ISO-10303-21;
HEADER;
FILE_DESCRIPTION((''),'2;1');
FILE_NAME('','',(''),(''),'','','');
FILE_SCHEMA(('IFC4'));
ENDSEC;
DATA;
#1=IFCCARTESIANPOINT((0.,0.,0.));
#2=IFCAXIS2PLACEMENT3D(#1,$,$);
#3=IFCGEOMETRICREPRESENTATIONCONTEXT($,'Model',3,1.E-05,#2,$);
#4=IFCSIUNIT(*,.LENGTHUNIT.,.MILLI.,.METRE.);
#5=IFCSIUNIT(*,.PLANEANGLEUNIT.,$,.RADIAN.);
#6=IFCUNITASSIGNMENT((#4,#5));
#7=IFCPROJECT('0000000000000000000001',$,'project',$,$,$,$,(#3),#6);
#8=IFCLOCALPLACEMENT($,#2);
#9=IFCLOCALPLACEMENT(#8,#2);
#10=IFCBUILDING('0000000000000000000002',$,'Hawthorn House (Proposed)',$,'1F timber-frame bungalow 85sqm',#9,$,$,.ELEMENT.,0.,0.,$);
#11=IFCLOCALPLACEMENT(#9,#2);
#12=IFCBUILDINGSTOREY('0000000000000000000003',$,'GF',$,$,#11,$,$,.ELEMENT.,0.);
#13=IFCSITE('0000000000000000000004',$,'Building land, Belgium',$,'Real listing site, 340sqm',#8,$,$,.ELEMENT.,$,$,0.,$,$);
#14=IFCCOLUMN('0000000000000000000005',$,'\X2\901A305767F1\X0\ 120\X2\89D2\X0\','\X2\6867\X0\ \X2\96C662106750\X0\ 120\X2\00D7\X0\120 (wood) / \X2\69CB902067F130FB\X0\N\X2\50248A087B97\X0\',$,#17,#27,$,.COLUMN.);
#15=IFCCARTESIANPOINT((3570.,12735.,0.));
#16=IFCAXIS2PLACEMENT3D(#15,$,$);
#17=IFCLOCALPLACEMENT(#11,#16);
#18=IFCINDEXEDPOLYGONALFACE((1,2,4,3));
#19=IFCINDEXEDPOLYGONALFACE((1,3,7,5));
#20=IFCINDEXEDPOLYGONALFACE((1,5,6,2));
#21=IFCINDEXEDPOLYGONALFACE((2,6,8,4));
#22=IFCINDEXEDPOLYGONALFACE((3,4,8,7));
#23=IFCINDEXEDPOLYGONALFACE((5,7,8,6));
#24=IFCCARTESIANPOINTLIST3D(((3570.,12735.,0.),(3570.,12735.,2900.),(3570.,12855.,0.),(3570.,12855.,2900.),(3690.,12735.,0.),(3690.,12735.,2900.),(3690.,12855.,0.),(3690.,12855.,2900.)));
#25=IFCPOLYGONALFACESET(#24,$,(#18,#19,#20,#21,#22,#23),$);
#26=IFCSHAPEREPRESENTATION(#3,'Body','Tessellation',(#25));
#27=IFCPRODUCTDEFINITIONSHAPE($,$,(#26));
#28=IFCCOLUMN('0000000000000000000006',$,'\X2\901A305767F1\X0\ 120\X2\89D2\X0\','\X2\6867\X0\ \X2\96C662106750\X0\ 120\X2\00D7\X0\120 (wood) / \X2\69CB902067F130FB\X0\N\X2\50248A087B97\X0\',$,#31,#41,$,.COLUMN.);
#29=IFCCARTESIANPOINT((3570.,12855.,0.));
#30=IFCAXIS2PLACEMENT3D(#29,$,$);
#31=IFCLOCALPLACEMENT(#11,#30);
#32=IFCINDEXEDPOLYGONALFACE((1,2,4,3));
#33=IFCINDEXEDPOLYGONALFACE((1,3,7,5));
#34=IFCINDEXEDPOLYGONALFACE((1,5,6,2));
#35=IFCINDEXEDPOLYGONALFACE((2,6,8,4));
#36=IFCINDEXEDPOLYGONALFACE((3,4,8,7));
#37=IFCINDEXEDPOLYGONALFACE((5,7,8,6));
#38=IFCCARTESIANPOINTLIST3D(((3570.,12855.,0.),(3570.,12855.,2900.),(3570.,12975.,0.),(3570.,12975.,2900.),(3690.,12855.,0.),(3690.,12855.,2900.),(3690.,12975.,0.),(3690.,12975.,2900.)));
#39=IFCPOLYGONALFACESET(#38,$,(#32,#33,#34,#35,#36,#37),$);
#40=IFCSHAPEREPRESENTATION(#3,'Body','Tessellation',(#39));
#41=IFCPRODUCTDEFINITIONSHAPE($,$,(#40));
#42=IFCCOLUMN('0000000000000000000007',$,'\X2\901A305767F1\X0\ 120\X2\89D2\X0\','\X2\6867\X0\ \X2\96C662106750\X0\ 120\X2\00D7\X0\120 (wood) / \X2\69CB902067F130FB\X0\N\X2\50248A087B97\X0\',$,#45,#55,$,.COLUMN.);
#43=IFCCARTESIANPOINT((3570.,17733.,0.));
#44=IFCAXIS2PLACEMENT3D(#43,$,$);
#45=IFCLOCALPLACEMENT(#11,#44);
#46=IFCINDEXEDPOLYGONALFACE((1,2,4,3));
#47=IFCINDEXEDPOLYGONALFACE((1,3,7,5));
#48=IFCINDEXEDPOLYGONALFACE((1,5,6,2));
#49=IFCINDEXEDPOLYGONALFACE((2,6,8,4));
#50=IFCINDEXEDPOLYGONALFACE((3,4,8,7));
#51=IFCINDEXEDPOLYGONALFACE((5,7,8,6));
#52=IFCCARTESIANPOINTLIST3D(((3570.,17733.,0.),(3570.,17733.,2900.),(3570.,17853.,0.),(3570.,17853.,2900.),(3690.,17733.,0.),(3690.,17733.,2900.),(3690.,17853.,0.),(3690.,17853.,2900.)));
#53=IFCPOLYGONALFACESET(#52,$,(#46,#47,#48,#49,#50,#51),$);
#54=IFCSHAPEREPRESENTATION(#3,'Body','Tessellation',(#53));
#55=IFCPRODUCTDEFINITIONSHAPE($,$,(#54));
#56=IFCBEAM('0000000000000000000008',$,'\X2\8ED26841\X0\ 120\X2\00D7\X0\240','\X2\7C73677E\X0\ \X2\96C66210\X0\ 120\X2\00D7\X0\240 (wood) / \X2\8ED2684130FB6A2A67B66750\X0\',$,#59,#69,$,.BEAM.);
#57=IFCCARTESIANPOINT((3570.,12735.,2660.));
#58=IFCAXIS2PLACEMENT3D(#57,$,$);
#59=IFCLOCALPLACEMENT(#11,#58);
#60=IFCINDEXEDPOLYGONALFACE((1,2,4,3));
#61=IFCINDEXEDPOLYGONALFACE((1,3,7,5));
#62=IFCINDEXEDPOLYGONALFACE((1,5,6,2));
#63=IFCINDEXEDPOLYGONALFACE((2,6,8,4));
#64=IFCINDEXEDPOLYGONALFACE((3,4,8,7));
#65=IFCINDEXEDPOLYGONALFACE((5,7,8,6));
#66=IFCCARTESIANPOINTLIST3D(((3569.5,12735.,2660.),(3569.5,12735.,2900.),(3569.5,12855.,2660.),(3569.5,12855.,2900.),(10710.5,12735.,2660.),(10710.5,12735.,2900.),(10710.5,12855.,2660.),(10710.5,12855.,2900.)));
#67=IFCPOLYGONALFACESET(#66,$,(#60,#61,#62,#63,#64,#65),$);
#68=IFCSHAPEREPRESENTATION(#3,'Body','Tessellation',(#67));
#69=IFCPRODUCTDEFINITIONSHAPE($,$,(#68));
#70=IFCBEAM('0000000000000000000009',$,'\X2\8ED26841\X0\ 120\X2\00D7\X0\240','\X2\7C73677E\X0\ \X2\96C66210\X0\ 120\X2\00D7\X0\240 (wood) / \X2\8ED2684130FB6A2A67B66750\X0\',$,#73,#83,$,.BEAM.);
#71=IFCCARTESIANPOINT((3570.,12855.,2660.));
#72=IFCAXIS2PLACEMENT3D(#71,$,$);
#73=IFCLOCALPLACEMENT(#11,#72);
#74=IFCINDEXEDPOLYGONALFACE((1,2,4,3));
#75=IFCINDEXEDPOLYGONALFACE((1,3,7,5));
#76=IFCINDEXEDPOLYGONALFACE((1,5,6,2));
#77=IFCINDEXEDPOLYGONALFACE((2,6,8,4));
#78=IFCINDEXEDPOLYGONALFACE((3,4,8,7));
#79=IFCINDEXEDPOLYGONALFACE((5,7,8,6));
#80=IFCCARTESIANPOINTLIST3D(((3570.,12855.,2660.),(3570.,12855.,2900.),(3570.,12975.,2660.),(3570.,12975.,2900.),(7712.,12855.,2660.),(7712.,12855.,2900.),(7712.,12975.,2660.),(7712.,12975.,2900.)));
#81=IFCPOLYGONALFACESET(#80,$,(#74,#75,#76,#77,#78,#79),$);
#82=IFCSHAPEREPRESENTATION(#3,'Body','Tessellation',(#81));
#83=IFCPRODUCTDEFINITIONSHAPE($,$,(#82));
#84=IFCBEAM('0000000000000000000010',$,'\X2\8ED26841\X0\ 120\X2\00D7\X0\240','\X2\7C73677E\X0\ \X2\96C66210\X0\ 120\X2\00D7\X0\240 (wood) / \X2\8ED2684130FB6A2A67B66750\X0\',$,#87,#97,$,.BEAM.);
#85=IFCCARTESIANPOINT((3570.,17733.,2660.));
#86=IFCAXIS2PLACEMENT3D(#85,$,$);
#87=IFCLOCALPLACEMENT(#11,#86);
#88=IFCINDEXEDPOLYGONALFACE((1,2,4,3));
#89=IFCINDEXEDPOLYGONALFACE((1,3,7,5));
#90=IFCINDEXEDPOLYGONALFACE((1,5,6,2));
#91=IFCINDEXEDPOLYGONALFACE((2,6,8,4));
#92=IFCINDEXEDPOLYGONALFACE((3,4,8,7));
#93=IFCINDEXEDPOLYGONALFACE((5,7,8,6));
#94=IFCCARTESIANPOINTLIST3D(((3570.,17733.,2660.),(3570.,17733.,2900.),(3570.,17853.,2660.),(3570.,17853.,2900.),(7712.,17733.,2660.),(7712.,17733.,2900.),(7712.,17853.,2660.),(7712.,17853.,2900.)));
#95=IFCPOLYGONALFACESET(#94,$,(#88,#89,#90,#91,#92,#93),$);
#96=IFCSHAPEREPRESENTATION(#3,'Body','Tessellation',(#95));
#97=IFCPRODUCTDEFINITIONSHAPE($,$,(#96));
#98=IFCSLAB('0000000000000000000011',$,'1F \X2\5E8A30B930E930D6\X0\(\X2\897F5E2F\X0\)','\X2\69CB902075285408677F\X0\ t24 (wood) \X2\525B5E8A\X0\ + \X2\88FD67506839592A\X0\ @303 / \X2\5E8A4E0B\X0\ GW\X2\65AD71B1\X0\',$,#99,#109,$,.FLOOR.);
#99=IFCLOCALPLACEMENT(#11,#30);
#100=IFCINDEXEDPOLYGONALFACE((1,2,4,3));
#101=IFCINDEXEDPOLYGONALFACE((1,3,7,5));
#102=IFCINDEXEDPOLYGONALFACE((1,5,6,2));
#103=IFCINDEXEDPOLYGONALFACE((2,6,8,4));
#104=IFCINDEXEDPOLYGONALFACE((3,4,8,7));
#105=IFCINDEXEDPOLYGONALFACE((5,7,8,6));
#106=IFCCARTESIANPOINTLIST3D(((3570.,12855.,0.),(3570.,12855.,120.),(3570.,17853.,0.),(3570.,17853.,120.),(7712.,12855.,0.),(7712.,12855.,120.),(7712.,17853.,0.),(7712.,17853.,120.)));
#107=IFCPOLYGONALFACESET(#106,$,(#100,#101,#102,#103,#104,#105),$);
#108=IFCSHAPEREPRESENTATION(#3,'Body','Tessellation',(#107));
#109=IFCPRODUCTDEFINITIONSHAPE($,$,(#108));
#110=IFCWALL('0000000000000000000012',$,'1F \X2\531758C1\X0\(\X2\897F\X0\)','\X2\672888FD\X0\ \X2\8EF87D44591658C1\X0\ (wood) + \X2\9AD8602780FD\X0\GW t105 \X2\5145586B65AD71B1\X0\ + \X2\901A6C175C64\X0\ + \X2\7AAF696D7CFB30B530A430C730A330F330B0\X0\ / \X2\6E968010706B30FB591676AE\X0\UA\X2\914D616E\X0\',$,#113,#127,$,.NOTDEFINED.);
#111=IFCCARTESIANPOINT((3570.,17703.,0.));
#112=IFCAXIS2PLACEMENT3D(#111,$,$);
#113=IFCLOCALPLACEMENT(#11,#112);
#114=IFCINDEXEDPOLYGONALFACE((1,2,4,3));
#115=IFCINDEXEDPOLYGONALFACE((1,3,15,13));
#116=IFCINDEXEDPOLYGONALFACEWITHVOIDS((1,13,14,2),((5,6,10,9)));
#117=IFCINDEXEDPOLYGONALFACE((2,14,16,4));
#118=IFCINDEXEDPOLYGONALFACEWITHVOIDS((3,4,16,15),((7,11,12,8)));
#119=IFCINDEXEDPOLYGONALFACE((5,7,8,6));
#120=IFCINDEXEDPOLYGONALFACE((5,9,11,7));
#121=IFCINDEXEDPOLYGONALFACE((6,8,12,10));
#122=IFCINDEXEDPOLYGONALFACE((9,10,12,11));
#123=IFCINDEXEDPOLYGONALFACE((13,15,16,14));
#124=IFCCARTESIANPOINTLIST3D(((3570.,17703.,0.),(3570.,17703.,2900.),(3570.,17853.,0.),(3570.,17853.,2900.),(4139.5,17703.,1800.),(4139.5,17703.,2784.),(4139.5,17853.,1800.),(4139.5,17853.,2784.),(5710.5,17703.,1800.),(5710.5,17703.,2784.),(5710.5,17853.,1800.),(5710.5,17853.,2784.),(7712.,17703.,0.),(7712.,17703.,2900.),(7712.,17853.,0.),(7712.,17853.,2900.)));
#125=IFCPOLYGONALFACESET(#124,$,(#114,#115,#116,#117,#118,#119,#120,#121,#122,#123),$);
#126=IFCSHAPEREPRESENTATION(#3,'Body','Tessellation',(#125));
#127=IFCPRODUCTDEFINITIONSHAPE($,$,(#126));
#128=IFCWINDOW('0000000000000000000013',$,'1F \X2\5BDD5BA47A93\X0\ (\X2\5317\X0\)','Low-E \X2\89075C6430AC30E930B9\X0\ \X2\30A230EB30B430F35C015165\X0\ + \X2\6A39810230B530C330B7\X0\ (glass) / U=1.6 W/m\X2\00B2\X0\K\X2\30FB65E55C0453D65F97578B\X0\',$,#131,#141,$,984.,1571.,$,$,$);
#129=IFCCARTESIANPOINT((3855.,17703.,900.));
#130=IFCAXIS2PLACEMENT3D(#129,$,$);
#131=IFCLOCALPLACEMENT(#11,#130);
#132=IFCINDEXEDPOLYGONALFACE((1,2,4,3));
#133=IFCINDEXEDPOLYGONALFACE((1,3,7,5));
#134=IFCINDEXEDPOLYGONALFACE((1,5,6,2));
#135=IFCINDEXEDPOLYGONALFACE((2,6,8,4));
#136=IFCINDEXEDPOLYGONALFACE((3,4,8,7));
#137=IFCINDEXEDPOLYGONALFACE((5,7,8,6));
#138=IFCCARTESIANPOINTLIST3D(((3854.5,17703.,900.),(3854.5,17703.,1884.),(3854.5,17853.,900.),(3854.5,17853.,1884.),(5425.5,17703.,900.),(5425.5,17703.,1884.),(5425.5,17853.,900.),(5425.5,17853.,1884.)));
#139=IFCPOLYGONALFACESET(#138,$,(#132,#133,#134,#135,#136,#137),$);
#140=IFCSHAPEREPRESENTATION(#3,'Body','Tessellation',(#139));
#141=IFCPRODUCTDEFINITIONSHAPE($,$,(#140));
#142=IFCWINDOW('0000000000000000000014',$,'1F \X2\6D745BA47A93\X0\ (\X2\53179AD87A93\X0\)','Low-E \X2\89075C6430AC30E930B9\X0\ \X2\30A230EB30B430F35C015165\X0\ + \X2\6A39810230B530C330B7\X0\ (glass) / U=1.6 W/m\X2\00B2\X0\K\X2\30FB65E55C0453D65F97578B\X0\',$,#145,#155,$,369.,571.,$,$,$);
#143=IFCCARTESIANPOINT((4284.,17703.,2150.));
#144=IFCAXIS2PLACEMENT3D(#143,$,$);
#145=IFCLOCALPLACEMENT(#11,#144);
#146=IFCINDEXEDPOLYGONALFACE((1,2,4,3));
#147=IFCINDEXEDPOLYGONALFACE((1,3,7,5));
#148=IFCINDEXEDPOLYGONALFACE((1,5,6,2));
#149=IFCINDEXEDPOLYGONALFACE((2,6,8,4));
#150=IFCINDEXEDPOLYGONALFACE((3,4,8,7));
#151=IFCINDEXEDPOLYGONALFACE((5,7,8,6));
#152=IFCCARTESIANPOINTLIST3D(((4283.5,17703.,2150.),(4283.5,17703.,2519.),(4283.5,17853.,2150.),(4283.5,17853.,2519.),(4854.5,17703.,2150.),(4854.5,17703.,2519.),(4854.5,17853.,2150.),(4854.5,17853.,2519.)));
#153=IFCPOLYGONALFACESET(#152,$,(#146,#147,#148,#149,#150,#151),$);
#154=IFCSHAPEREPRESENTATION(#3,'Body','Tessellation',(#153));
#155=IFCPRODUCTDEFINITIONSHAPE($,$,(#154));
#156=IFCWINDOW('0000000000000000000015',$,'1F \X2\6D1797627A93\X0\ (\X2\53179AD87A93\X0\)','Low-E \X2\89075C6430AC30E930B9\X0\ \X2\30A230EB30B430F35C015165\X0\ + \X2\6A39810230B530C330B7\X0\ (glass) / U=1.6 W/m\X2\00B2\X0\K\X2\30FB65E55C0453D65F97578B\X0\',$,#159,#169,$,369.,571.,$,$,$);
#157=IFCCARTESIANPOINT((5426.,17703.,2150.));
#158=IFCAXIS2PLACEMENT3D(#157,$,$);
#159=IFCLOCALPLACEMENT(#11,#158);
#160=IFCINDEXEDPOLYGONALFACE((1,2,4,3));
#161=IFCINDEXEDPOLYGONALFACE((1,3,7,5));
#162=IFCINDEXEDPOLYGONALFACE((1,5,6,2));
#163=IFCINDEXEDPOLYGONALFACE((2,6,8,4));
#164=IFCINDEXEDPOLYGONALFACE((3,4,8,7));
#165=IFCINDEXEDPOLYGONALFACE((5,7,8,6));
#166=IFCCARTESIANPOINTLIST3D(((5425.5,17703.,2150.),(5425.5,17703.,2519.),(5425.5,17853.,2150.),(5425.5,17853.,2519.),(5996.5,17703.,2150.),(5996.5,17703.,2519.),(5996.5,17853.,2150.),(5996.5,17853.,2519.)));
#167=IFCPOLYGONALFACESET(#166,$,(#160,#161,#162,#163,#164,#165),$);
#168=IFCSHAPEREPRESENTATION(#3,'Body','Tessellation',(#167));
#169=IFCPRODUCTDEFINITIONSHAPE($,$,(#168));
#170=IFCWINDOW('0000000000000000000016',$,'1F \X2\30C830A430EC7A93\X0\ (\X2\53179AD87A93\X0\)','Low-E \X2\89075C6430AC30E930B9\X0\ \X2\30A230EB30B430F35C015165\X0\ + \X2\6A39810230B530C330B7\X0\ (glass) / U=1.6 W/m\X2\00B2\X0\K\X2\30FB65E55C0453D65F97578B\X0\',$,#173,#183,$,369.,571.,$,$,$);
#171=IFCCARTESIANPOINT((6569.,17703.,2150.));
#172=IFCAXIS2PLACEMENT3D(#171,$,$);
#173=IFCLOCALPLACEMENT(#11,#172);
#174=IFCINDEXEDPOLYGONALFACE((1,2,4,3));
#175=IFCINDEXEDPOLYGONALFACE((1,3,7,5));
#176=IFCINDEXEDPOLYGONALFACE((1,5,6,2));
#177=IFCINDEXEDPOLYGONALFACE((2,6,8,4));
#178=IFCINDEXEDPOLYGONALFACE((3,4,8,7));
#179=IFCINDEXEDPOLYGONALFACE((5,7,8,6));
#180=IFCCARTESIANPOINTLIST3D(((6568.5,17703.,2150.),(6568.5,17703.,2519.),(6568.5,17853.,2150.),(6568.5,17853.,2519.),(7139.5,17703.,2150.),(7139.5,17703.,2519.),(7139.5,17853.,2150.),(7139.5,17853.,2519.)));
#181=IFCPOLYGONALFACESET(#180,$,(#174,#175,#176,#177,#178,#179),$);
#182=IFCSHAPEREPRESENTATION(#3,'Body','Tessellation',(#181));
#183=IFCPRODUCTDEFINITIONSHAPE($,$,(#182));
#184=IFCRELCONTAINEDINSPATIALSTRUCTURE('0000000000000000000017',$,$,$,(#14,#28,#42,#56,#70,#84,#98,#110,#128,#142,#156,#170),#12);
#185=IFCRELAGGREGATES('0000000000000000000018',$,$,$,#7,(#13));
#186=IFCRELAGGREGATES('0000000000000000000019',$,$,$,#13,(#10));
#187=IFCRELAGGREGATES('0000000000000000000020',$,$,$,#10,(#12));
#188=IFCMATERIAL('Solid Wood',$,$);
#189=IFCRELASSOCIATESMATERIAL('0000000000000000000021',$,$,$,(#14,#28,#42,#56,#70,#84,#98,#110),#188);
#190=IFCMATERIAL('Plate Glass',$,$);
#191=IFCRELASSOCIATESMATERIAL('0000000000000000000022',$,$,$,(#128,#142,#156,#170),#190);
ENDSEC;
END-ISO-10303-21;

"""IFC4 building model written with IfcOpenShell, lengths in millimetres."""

from ifc_helpers import new_model, si_unit, frame, frame_2d, origin, place, context, project, spatial, rectangle, extrude, material, element, fill, save


model = new_model("IFC4")

# Units and contexts
model_context = context("Model", 3, precision=1e-05, world=origin())
ifc_project = project(units=[si_unit("LENGTHUNIT", "METRE", prefix="MILLI"), si_unit("PLANEANGLEUNIT", "RADIAN")], contexts=[model_context])

# Site, building, storey
site_placement = place(None, origin())
site = spatial("IfcSite", under=ifc_project, at=site_placement, Name="Building land, Belgium", ObjectType="Real listing site, 340sqm", CompositionType="ELEMENT", RefElevation=0.0)
building_placement = place(site_placement, origin())
building = spatial("IfcBuilding", under=site, at=building_placement, Name="Hawthorn House (Proposed)", ObjectType="1F timber-frame bungalow 85sqm", CompositionType="ELEMENT", ElevationOfRefHeight=0.0, ElevationOfTerrain=0.0)
storey_placement = place(building_placement, origin())
storey = spatial("IfcBuildingStorey", under=building, at=storey_placement, Name="GF", CompositionType="ELEMENT", Elevation=0.0)

# Columns
ifc_material_1 = material(Name="Solid Wood")
column_1_placement = place(storey_placement, frame((3570.0, 12735.0, 0.0)))
element("IfcColumn", 1, at=column_1_placement, inside=storey, material=ifc_material_1, Name="通し柱 120角", Description="桧 集成材 120×120 (wood) / 構造柱・N値計算", PredefinedType="COLUMN", context=model_context, shape_type="SweptSolid", body=[
    extrude(rectangle(XDim=120.0, YDim=120.0, at=frame_2d((60.0, 60.0))), frame((3570.0, 12735.0, 0.0)), (0.0, 0.0, 1.0), 2900.0),
])
column_2_placement = place(storey_placement, frame((3570.0, 12855.0, 0.0)))
element("IfcColumn", 2, at=column_2_placement, inside=storey, material=ifc_material_1, Name="通し柱 120角", Description="桧 集成材 120×120 (wood) / 構造柱・N値計算", PredefinedType="COLUMN", context=model_context, shape_type="SweptSolid", body=[
    extrude(rectangle(XDim=120.0, YDim=120.0, at=frame_2d((60.0, 60.0))), frame((3570.0, 12855.0, 0.0)), (0.0, 0.0, 1.0), 2900.0),
])
column_3_placement = place(storey_placement, frame((3570.0, 17733.0, 0.0)))
element("IfcColumn", 3, at=column_3_placement, inside=storey, material=ifc_material_1, Name="通し柱 120角", Description="桧 集成材 120×120 (wood) / 構造柱・N値計算", PredefinedType="COLUMN", context=model_context, shape_type="SweptSolid", body=[
    extrude(rectangle(XDim=120.0, YDim=120.0, at=frame_2d((60.0, 60.0))), frame((3570.0, 17733.0, 0.0)), (0.0, 0.0, 1.0), 2900.0),
])

# Beams
beam_1_placement = place(storey_placement, frame((3570.0, 12735.0, 2660.0)))
element("IfcBeam", 4, at=beam_1_placement, inside=storey, material=ifc_material_1, Name="軒桁 120×240", Description="米松 集成 120×240 (wood) / 軒桁・横架材", PredefinedType="BEAM", context=model_context, shape_type="SweptSolid", body=[
    extrude(rectangle(XDim=7141.0, YDim=120.0, at=frame_2d((3570.0, 60.0))), frame((3570.0, 12735.0, 2660.0)), (0.0, 0.0, 1.0), 240.0),
])
beam_2_placement = place(storey_placement, frame((3570.0, 12855.0, 2660.0)))
element("IfcBeam", 5, at=beam_2_placement, inside=storey, material=ifc_material_1, Name="軒桁 120×240", Description="米松 集成 120×240 (wood) / 軒桁・横架材", PredefinedType="BEAM", context=model_context, shape_type="SweptSolid", body=[
    extrude(rectangle(XDim=4142.0, YDim=120.0, at=frame_2d((2071.0, 60.0))), frame((3570.0, 12855.0, 2660.0)), (0.0, 0.0, 1.0), 240.0),
])
beam_3_placement = place(storey_placement, frame((3570.0, 17733.0, 2660.0)))
element("IfcBeam", 6, at=beam_3_placement, inside=storey, material=ifc_material_1, Name="軒桁 120×240", Description="米松 集成 120×240 (wood) / 軒桁・横架材", PredefinedType="BEAM", context=model_context, shape_type="SweptSolid", body=[
    extrude(rectangle(XDim=4142.0, YDim=120.0, at=frame_2d((2071.0, 60.0))), frame((3570.0, 17733.0, 2660.0)), (0.0, 0.0, 1.0), 240.0),
])

# Slab
slab_placement = place(storey_placement, frame((3570.0, 12855.0, 0.0)))
element("IfcSlab", 7, at=slab_placement, inside=storey, material=ifc_material_1, Name="1F 床スラブ(西帯)", Description="構造用合板 t24 (wood) 剛床 + 製材根太 @303 / 床下 GW断熱", PredefinedType="FLOOR", context=model_context, shape_type="SweptSolid", body=[
    extrude(rectangle(XDim=4142.0, YDim=4998.0, at=frame_2d((2071.0, 2499.0))), frame((3570.0, 12855.0, 0.0)), (0.0, 0.0, 1.0), 120.0),
])

# Wall, openings, windows
wall_1_placement = place(storey_placement, frame((3570.0, 17703.0, 0.0)))
wall_1 = element("IfcWall", 8, at=wall_1_placement, inside=storey, material=ifc_material_1, Name="1F 北壁(西)", Description="木製 軸組外壁 (wood) + 高性能GW t105 充填断熱 + 通気層 + 窯業系サイディング / 準耐火・外皮UA配慮", PredefinedType="NOTDEFINED", context=model_context, shape_type="SweptSolid", body=[
    extrude(rectangle(XDim=4142.0, YDim=150.0, at=frame_2d((2071.0, 75.0))), frame((3570.0, 17703.0, 0.0)), (0.0, 0.0, 1.0), 2900.0),
])
opening_1_placement = place(storey_placement, frame((3855.0, 17703.0, 900.0)))
opening_1 = element("IfcOpeningElement", 9, at=opening_1_placement, cuts=wall_1, PredefinedType="NOTDEFINED", context=model_context, shape_type="SweptSolid", body=[
    extrude(rectangle(XDim=1571.0, YDim=150.0, at=frame_2d((785.0, 75.0))), frame((3855.0, 17703.0, 900.0)), (0.0, 0.0, 1.0), 984.0),
])
opening_2_placement = place(storey_placement, frame((4284.0, 17703.0, 2150.0)))
opening_2 = element("IfcOpeningElement", 10, at=opening_2_placement, cuts=wall_1, PredefinedType="NOTDEFINED", context=model_context, shape_type="SweptSolid", body=[
    extrude(rectangle(XDim=571.0, YDim=150.0, at=frame_2d((285.0, 75.0))), frame((4284.0, 17703.0, 2150.0)), (0.0, 0.0, 1.0), 369.0),
])
opening_3_placement = place(storey_placement, frame((5426.0, 17703.0, 2150.0)))
opening_3 = element("IfcOpeningElement", 11, at=opening_3_placement, cuts=wall_1, PredefinedType="NOTDEFINED", context=model_context, shape_type="SweptSolid", body=[
    extrude(rectangle(XDim=571.0, YDim=150.0, at=frame_2d((285.0, 75.0))), frame((5426.0, 17703.0, 2150.0)), (0.0, 0.0, 1.0), 369.0),
])
opening_4_placement = place(storey_placement, frame((6569.0, 17703.0, 2150.0)))
opening_4 = element("IfcOpeningElement", 12, at=opening_4_placement, cuts=wall_1, PredefinedType="NOTDEFINED", context=model_context, shape_type="SweptSolid", body=[
    extrude(rectangle(XDim=571.0, YDim=150.0, at=frame_2d((285.0, 75.0))), frame((6569.0, 17703.0, 2150.0)), (0.0, 0.0, 1.0), 369.0),
])
ifc_material_2 = material(Name="Plate Glass")
window_1_placement = place(storey_placement, frame((3855.0, 17703.0, 900.0)))
window_1 = element("IfcWindow", 13, at=window_1_placement, inside=storey, material=ifc_material_2, Name="1F 寝室窓 (北)", Description="Low-E 複層ガラス アルゴン封入 + 樹脂サッシ (glass) / U=1.6 W/m²K・日射取得型", OverallHeight=984.0, OverallWidth=1571.0, context=model_context, shape_type="SweptSolid", body=[
    extrude(rectangle(XDim=1571.0, YDim=150.0, at=frame_2d((785.0, 75.0))), frame((3855.0, 17703.0, 900.0)), (0.0, 0.0, 1.0), 984.0),
])
fill(opening_1, window_1)
window_2_placement = place(storey_placement, frame((4284.0, 17703.0, 2150.0)))
window_2 = element("IfcWindow", 14, at=window_2_placement, inside=storey, material=ifc_material_2, Name="1F 浴室窓 (北高窓)", Description="Low-E 複層ガラス アルゴン封入 + 樹脂サッシ (glass) / U=1.6 W/m²K・日射取得型", OverallHeight=369.0, OverallWidth=571.0, context=model_context, shape_type="SweptSolid", body=[
    extrude(rectangle(XDim=571.0, YDim=150.0, at=frame_2d((285.0, 75.0))), frame((4284.0, 17703.0, 2150.0)), (0.0, 0.0, 1.0), 369.0),
])
fill(opening_2, window_2)
window_3_placement = place(storey_placement, frame((5426.0, 17703.0, 2150.0)))
window_3 = element("IfcWindow", 15, at=window_3_placement, inside=storey, material=ifc_material_2, Name="1F 洗面窓 (北高窓)", Description="Low-E 複層ガラス アルゴン封入 + 樹脂サッシ (glass) / U=1.6 W/m²K・日射取得型", OverallHeight=369.0, OverallWidth=571.0, context=model_context, shape_type="SweptSolid", body=[
    extrude(rectangle(XDim=571.0, YDim=150.0, at=frame_2d((285.0, 75.0))), frame((5426.0, 17703.0, 2150.0)), (0.0, 0.0, 1.0), 369.0),
])
fill(opening_3, window_3)
window_4_placement = place(storey_placement, frame((6569.0, 17703.0, 2150.0)))
window_4 = element("IfcWindow", 16, at=window_4_placement, inside=storey, material=ifc_material_2, Name="1F トイレ窓 (北高窓)", Description="Low-E 複層ガラス アルゴン封入 + 樹脂サッシ (glass) / U=1.6 W/m²K・日射取得型", OverallHeight=369.0, OverallWidth=571.0, context=model_context, shape_type="SweptSolid", body=[
    extrude(rectangle(XDim=571.0, YDim=150.0, at=frame_2d((285.0, 75.0))), frame((6569.0, 17703.0, 2150.0)), (0.0, 0.0, 1.0), 369.0),
])
fill(opening_4, window_4)

save(model, "model.ifc")
